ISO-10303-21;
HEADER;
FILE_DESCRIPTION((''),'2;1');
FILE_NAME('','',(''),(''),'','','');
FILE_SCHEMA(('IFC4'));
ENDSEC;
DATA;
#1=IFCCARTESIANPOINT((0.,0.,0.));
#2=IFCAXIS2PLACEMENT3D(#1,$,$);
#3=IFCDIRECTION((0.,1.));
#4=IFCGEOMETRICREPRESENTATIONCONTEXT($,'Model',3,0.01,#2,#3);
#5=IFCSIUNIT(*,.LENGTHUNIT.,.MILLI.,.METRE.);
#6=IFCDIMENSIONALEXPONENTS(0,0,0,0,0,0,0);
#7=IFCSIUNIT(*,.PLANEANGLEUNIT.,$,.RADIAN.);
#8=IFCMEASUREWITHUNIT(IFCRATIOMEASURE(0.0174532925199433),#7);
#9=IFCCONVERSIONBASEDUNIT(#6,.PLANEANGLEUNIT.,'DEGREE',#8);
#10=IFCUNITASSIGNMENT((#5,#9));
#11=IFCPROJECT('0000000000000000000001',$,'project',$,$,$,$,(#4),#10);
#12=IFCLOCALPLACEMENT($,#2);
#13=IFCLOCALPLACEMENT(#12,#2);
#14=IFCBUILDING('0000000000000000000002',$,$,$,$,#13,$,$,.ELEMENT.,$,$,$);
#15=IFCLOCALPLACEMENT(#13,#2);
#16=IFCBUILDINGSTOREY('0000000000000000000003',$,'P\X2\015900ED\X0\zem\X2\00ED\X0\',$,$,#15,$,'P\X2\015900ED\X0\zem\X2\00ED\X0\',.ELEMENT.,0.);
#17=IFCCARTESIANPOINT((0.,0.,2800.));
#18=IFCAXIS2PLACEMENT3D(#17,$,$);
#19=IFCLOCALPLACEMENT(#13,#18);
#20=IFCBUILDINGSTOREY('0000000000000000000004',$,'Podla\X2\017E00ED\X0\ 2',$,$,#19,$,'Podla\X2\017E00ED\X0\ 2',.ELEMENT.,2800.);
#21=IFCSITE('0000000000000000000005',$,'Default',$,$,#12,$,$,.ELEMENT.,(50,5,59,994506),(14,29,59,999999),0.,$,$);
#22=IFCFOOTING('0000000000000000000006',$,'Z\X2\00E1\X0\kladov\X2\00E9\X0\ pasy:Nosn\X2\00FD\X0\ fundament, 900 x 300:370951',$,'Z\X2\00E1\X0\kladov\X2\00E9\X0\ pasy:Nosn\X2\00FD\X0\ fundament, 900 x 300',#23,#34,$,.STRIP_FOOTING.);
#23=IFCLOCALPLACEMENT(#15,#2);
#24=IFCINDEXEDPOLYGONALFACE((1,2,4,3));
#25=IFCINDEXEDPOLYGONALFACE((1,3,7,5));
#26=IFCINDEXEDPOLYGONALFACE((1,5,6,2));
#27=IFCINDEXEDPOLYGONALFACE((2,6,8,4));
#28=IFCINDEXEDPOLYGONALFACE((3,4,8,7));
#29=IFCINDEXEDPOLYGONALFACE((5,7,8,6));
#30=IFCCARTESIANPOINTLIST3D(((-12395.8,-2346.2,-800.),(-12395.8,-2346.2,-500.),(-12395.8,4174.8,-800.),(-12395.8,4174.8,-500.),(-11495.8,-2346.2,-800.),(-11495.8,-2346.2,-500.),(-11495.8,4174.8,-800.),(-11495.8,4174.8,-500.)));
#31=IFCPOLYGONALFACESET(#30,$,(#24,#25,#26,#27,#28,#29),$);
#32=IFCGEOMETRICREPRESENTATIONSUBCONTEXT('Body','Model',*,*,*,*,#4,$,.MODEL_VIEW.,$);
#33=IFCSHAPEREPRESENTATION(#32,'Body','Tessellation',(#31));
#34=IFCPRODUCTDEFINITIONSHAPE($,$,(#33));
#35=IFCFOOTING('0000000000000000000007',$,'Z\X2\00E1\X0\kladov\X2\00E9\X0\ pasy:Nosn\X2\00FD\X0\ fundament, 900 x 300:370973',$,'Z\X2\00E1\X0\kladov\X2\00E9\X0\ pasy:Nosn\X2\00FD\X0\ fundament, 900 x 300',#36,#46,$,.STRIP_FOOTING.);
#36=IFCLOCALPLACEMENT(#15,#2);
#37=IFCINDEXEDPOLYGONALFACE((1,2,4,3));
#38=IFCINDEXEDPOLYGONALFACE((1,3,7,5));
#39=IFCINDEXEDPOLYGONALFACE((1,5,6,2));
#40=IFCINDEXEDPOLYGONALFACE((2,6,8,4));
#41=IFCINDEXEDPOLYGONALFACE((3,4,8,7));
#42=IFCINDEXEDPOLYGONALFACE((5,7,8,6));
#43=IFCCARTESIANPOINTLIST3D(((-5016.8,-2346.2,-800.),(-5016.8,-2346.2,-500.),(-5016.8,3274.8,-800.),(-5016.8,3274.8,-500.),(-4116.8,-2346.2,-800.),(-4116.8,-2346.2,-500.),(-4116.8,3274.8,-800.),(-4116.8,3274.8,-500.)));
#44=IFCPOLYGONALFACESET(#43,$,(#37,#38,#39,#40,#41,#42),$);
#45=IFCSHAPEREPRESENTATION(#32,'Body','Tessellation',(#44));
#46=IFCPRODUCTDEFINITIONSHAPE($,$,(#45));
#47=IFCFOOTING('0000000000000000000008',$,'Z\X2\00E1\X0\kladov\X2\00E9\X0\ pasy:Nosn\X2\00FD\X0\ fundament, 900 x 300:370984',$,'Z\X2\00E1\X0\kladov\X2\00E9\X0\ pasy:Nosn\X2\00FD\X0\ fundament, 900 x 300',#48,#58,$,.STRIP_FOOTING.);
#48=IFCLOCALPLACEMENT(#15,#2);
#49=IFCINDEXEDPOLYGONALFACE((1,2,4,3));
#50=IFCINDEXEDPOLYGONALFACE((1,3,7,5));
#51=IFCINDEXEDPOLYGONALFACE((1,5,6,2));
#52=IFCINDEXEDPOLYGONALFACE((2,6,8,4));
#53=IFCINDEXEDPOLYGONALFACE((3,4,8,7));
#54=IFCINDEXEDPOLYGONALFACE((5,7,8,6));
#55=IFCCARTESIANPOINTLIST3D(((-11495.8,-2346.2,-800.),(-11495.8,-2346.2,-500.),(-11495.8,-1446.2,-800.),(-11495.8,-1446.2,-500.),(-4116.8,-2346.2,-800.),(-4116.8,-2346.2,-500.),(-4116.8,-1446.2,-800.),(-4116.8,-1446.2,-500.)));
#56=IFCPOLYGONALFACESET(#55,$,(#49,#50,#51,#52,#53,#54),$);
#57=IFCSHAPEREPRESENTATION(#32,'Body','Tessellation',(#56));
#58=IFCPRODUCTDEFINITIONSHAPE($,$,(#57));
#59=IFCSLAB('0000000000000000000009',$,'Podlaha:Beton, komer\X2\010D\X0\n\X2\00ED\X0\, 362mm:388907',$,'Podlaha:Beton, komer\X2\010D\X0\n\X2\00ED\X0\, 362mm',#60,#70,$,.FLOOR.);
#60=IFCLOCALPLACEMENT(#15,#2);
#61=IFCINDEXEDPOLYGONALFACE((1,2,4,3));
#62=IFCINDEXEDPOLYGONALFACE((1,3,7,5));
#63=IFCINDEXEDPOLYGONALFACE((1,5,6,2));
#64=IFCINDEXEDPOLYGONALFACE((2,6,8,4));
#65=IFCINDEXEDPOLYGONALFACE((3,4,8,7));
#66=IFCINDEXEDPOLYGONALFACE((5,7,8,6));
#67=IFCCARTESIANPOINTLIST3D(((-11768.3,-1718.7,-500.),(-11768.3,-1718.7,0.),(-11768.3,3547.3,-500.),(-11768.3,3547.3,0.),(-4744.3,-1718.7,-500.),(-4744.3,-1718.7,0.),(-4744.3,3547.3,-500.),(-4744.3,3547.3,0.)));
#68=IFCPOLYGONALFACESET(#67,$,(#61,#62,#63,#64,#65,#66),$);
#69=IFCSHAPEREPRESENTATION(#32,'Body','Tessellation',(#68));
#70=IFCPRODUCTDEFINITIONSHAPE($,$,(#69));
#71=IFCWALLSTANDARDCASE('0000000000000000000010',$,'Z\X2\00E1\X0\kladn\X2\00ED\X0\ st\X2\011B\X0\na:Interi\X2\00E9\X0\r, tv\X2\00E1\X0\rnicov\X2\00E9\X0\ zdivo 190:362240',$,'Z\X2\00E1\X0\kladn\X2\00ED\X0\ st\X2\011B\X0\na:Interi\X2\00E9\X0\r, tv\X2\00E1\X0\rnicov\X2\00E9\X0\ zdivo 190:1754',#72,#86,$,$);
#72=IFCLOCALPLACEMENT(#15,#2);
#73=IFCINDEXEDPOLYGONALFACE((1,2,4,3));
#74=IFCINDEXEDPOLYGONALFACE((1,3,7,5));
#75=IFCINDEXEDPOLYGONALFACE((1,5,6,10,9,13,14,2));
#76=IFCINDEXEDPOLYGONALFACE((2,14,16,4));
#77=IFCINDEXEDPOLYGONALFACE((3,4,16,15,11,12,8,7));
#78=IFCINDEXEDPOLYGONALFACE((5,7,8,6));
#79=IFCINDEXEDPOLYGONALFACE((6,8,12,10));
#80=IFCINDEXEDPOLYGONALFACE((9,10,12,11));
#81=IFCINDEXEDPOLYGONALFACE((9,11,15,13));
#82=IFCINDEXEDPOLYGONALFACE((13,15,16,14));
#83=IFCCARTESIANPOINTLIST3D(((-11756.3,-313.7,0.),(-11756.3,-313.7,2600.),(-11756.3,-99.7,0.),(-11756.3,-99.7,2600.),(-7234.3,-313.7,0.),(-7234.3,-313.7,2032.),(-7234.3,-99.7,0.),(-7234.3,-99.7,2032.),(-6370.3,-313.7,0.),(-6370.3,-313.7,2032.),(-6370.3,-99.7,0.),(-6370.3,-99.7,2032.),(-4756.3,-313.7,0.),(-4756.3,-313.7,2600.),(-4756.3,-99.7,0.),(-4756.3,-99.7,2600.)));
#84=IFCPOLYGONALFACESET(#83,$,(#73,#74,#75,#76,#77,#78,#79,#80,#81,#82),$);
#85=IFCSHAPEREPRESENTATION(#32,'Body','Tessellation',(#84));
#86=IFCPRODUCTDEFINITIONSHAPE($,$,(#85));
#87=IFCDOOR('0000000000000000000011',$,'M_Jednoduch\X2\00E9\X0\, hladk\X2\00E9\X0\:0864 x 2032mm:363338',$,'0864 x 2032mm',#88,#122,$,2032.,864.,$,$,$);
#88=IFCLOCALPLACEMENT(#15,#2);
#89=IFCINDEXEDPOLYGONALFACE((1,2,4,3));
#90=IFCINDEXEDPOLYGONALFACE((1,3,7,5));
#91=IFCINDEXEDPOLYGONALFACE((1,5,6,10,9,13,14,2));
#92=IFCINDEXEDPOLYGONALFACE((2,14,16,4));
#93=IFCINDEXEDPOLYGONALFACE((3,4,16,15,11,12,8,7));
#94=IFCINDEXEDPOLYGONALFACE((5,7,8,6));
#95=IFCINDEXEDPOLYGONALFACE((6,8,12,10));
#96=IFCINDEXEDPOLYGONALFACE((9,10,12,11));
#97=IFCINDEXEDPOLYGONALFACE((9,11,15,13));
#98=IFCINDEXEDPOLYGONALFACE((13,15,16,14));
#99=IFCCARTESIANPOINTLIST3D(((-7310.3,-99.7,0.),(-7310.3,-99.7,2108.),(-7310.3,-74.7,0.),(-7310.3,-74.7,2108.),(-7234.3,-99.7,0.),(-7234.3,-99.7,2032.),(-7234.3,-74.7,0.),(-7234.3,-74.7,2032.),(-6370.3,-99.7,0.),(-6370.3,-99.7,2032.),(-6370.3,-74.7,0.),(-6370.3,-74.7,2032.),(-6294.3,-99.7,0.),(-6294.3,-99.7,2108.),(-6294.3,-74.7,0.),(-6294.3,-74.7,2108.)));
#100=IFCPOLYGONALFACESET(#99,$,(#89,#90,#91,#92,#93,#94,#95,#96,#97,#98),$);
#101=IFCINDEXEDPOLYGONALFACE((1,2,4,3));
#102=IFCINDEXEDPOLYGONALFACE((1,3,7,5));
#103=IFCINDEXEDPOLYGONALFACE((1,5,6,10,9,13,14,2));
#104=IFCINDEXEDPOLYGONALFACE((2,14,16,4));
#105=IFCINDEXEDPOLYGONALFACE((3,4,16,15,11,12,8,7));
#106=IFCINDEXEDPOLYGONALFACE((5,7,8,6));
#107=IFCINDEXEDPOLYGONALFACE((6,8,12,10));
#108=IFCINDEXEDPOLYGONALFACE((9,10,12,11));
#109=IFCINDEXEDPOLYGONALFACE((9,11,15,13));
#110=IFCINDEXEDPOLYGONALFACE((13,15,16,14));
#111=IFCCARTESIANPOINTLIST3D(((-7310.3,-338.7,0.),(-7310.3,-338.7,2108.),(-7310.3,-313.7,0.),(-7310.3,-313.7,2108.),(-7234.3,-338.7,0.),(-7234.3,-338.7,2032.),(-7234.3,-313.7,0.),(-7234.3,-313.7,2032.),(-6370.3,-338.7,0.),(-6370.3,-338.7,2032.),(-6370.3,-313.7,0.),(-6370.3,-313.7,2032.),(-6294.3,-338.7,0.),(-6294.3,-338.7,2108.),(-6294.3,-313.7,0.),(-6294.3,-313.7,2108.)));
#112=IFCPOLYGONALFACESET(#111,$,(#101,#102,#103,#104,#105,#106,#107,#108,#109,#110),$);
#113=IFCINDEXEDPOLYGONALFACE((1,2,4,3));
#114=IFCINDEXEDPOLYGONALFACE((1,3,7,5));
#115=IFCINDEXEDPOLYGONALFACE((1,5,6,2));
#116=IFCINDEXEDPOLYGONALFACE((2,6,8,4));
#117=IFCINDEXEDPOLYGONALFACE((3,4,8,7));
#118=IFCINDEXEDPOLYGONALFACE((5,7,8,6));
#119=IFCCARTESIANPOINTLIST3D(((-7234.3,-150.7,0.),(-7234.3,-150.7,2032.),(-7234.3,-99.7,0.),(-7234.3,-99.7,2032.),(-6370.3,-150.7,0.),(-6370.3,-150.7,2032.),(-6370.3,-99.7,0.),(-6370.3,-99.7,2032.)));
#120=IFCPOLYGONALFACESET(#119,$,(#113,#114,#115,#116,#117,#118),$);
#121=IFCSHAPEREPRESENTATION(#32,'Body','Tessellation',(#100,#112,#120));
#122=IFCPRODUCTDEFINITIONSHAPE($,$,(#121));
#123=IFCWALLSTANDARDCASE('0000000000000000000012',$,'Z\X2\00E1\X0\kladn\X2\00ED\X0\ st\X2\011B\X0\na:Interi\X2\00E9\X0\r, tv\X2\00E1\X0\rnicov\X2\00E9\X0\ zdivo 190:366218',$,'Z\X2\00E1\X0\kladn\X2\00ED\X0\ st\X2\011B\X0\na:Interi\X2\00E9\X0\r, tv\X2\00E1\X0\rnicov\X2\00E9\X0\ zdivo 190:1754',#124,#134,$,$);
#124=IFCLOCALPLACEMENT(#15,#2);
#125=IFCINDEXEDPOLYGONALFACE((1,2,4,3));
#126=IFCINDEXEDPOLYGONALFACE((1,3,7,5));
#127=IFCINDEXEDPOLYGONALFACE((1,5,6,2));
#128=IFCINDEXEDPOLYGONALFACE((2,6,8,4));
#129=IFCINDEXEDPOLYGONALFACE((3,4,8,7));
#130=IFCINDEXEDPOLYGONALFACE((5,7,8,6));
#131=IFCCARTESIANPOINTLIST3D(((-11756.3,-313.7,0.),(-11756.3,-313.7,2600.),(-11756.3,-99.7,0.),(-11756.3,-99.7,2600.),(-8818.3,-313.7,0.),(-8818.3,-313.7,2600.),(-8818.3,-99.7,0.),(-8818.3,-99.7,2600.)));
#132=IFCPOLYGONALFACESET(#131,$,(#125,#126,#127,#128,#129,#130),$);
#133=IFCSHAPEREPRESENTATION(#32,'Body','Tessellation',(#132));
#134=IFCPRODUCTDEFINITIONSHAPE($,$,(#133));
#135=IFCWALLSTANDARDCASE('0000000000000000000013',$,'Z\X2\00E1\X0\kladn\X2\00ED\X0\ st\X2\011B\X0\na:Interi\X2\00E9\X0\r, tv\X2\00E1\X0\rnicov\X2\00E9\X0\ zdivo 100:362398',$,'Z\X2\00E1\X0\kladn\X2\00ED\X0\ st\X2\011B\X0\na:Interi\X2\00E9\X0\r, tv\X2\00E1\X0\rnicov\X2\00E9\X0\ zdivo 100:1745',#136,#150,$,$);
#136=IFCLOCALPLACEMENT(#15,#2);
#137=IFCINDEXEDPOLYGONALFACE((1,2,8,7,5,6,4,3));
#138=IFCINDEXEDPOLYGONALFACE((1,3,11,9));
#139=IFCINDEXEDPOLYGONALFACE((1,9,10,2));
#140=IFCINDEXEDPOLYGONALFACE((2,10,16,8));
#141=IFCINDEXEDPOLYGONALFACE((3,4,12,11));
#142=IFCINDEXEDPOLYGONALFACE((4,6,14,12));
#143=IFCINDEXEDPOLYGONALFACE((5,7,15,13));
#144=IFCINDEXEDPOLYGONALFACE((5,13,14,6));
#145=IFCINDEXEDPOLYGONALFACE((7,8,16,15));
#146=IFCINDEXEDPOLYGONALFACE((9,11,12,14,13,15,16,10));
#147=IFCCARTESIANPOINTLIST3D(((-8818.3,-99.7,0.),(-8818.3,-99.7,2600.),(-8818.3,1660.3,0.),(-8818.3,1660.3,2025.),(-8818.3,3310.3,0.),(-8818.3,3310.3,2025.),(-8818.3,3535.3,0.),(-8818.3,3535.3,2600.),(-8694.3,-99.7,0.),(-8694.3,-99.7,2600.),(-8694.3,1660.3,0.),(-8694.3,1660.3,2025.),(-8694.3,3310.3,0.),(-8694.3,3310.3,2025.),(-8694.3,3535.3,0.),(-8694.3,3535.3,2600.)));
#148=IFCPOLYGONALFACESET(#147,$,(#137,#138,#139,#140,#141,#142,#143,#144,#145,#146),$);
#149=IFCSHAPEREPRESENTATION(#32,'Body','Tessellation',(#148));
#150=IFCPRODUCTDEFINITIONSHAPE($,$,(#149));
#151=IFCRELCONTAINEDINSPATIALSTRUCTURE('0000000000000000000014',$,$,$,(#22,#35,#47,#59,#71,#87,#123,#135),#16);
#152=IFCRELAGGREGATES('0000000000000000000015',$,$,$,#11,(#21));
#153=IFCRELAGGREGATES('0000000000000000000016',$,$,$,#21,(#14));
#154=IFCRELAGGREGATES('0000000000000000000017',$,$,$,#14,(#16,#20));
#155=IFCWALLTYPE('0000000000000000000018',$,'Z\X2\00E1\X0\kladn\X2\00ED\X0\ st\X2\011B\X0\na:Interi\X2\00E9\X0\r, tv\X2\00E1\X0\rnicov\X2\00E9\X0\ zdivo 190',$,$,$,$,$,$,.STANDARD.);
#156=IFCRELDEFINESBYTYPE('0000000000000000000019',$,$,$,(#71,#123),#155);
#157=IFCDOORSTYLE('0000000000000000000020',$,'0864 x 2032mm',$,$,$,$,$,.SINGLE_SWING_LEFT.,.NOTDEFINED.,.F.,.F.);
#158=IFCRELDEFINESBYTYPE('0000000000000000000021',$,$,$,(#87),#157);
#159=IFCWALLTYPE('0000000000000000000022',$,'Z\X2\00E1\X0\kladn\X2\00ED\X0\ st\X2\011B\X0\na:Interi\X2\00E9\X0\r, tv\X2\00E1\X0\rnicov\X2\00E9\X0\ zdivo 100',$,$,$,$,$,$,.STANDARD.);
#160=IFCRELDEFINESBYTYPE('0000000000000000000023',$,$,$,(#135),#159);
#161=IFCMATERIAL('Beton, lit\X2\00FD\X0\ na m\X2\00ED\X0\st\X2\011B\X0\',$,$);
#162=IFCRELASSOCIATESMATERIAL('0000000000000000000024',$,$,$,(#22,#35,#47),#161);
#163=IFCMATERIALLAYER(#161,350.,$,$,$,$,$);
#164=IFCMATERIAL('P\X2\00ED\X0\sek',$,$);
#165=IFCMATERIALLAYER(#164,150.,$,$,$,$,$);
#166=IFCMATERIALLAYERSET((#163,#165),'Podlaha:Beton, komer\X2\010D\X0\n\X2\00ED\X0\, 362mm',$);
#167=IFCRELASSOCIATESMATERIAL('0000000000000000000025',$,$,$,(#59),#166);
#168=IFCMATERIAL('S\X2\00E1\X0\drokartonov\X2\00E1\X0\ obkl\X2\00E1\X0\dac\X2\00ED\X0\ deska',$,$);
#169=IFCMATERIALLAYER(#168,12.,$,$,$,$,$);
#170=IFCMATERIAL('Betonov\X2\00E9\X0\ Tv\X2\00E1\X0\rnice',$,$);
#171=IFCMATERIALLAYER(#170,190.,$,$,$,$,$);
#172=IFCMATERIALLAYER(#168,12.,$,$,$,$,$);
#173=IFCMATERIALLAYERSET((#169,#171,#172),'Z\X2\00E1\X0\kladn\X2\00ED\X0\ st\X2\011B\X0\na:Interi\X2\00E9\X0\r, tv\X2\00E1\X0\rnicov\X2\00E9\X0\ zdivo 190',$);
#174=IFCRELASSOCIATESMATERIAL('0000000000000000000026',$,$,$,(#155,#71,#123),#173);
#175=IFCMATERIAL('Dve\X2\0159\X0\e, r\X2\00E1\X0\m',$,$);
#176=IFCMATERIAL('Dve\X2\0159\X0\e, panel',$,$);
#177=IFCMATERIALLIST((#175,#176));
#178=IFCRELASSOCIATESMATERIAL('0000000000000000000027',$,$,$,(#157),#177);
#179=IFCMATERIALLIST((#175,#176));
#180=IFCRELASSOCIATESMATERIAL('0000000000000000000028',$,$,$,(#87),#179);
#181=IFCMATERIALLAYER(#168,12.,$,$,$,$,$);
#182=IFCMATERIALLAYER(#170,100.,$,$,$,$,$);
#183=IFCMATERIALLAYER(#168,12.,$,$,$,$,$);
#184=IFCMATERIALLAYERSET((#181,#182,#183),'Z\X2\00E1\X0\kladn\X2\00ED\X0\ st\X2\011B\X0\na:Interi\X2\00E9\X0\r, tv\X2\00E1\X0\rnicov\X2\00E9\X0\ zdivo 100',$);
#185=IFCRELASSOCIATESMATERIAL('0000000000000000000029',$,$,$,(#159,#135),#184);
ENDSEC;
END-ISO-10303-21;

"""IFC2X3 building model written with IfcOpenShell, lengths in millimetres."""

from ifc_helpers import new_model, entity, si_unit, converted_unit, direction, frame, frame_2d, origin, origin_2d_with_axis, place, context, subcontext, project, spatial, polyline, rectangle, outline, extrude, clip, bounded_halfspace, source, transform, mapped, material, material_list, layer, layer_set, layer_usage, type_object, type_shapes, element, fill, save


model = new_model("IFC2X3")

# Units and contexts
model_context = context("Model", 3, precision=0.01, world=origin(), true_north=direction((0.0, 1.0)))
body_context = subcontext(model_context, "Body", "Model", "MODEL_VIEW")
ifc_project = project(units=[si_unit("LENGTHUNIT", "METRE", prefix="MILLI"), converted_unit("PLANEANGLEUNIT", "DEGREE", entity("IfcRatioMeasure", 0.0174532925199433), si_unit("PLANEANGLEUNIT", "RADIAN"), dimensions=[0, 0, 0, 0, 0, 0, 0])], contexts=[model_context])

# Site, building, storey
site_placement = place(None, origin())
site = spatial("IfcSite", under=ifc_project, at=site_placement, Name="Default", CompositionType="ELEMENT", RefLatitude=(50, 5, 59, 994506), RefLongitude=(14, 29, 59, 999999), RefElevation=0.0)
building_placement = place(site_placement, origin())
building = spatial("IfcBuilding", under=site, at=building_placement, CompositionType="ELEMENT")
storey_1_placement = place(building_placement, origin())
storey_1 = spatial("IfcBuildingStorey", under=building, at=storey_1_placement, Name="Přízemí", LongName="Přízemí", CompositionType="ELEMENT", Elevation=0.0)

# Footings
ifc_material_1 = material(Name="Beton, litý na místě")
footing_1_placement = place(storey_1_placement, origin())
element("IfcFooting", 1, at=footing_1_placement, inside=storey_1, material=ifc_material_1, Name="Základové pasy:Nosný fundament, 900 x 300:370951", ObjectType="Základové pasy:Nosný fundament, 900 x 300", PredefinedType="STRIP_FOOTING", context=body_context, shape_type="SweptSolid", body=[
    extrude(rectangle(XDim=6521.0, YDim=900.0, at=frame_2d((0.0, -150.0), x_axis=(1.0, 0.0))), frame((-11795.8, 914.3, -800.0), z_axis=(0.0, 0.0, 1.0), x_axis=(0.0, -1.0, 0.0)), (0.0, 0.0, 1.0), 300.0),
])
footing_2_placement = place(storey_1_placement, origin())
element("IfcFooting", 2, at=footing_2_placement, inside=storey_1, material=ifc_material_1, Name="Základové pasy:Nosný fundament, 900 x 300:370973", ObjectType="Základové pasy:Nosný fundament, 900 x 300", PredefinedType="STRIP_FOOTING", context=body_context, shape_type="SweptSolid", body=[
    extrude(rectangle(XDim=5621.0, YDim=900.0, at=frame_2d((0.0, 0.0), x_axis=(1.0, 0.0))), frame((-4566.8, 464.3, -800.0), z_axis=(0.0, 0.0, 1.0), x_axis=(0.0, 1.0, 0.0)), (0.0, 0.0, 1.0), 300.0),
])
footing_3_placement = place(storey_1_placement, origin())
element("IfcFooting", 3, at=footing_3_placement, inside=storey_1, material=ifc_material_1, Name="Základové pasy:Nosný fundament, 900 x 300:370984", ObjectType="Základové pasy:Nosný fundament, 900 x 300", PredefinedType="STRIP_FOOTING", context=body_context, shape_type="SweptSolid", body=[
    extrude(rectangle(XDim=7379.0, YDim=900.0, at=origin_2d_with_axis()), frame((-7806.3, -1896.2, -800.0), z_axis=(0.0, 0.0, 1.0), x_axis=(-1.0, 0.0, 0.0)), (0.0, 0.0, 1.0), 300.0),
])

# Slab
ifc_layer_1 = layer(ifc_material_1, 350.0)
ifc_material_2 = material(Name="Písek")
ifc_layer_2 = layer(ifc_material_2, 150.0)
ifc_layer_set_1 = layer_set([ifc_layer_1, ifc_layer_2], Name="Podlaha:Beton, komerční, 362mm")
ifc_layer_usage_1 = layer_usage(ifc_layer_set_1, "AXIS3", "POSITIVE", 0.0)
slab_placement = place(storey_1_placement, origin())
element("IfcSlab", 4, at=slab_placement, inside=storey_1, material=ifc_layer_usage_1, Name="Podlaha:Beton, komerční, 362mm:388907", ObjectType="Podlaha:Beton, komerční, 362mm", PredefinedType="FLOOR", context=body_context, shape_type="SweptSolid", body=[
    extrude(rectangle(XDim=5266.0, YDim=7024.0, at=frame_2d((0.0, 0.0), x_axis=(1.0, 0.0))), frame((-8256.3, 914.3, 0.0), z_axis=(0.0, 0.0, -1.0), x_axis=(0.0, 1.0, 0.0)), (0.0, 0.0, 1.0), 500.0),
])

# Shared definitions
ifc_material_3 = material(Name="Betonové Tvárnice")
ifc_material_4 = material(Name="Sádrokartonová obkládací deska")

# Shared definitions
storey_2_placement = place(building_placement, frame((0.0, 0.0, 2800.0)))
storey_2 = spatial("IfcBuildingStorey", under=building, at=storey_2_placement, Name="Podlaží 2", LongName="Podlaží 2", CompositionType="ELEMENT", Elevation=2800.0)

# Wall, opening, door
ifc_layer_3 = layer(ifc_material_4, 12.0)
ifc_layer_4 = layer(ifc_material_3, 190.0)
ifc_layer_5 = layer(ifc_material_4, 12.0)
ifc_layer_set_2 = layer_set([ifc_layer_3, ifc_layer_4, ifc_layer_5], Name="Základní stěna:Interiér, tvárnicové zdivo 190")
ifc_layer_usage_2 = layer_usage(ifc_layer_set_2, "AXIS2", "NEGATIVE", 107.0)
wall_type_1 = type_object("IfcWallType", Name="Základní stěna:Interiér, tvárnicové zdivo 190", PredefinedType="STANDARD", material=ifc_layer_set_2)
wall_1_placement = place(storey_1_placement, frame((-4756.3, -206.7, 0.0), z_axis=(0.0, 0.0, 1.0), x_axis=(-1.0, 0.0, 0.0)))
wall_1 = element("IfcWallStandardCase", 5, at=wall_1_placement, inside=storey_1, type_object=wall_type_1, material=ifc_layer_usage_2, Name="Základní stěna:Interiér, tvárnicové zdivo 190:362240", ObjectType="Základní stěna:Interiér, tvárnicové zdivo 190:1754", context=body_context, shape_type="Clipping", body=[
    clip(extrude(rectangle(XDim=7000.0, YDim=214.0, at=frame_2d((3500.0, 0.0), x_axis=(-1.0, 0.0))), origin(), (0.0, 0.0, 1.0), 2600.0), bounded_halfspace(frame((0.0, -107.0, 2600.0), z_axis=(0.0, 0.0, -1.0), x_axis=(-1.0, 0.0, 0.0)), True, frame((0.0, -107.0, 2600.0)), polyline([(0.0, 0.0), (1414.0, 0.0), (1538.0, 0.0), (3938.0, 0.0), (4062.0, 0.0), (7000.0, 0.0), (7000.0, 214.0), (0.0, 214.0), (0.0, 0.0)]))),
])
opening_1_placement = place(wall_1_placement, frame((2478.0, 107.0, 0.0)))
opening_1 = element("IfcOpeningElement", 6, at=opening_1_placement, cuts=wall_1, ObjectType="Opening", context=body_context, shape_type="SweptSolid", body=[
    extrude(rectangle(XDim=864.0, YDim=2032.0, at=frame_2d((1016.0, 432.0), x_axis=(0.0, -1.0))), frame((0.0, 0.0, 0.0), z_axis=(0.0, -1.0, 0.0), x_axis=(0.0, 0.0, 1.0)), (0.0, 0.0, 1.0), 214.0),
])
ifc_material_5 = material(Name="Dveře, rám")
ifc_material_6 = material(Name="Dveře, panel")
ifc_material_list_1 = material_list([ifc_material_5, ifc_material_6])
ifc_material_list_2 = material_list([ifc_material_5, ifc_material_6])
door_style_1 = type_object("IfcDoorStyle", Name="0864 x 2032mm", ConstructionType="NOTDEFINED", OperationType="SINGLE_SWING_LEFT", ParameterTakesPrecedence=False, Sizeable=False, material=ifc_material_list_2)
shared_shape_1 = source(origin(), body_context, "Body", "SweptSolid", [
    extrude(outline(polyline([(-508.0, -1073.0), (508.0, -1073.0), (508.0, 1035.0), (432.0, 1035.0), (432.0, -997.0), (-432.0, -997.0), (-432.0, 1035.0), (-508.0, 1035.0), (-508.0, -1073.0)])), frame((432.0, 239.0, 1035.0), z_axis=(0.0, -1.0, 0.0), x_axis=(-1.0, 0.0, 0.0)), (0.0, 0.0, 1.0), 25.0),
    extrude(outline(polyline([(-1073.0, -508.0), (1035.0, -508.0), (1035.0, -432.0), (-997.0, -432.0), (-997.0, 432.0), (1035.0, 432.0), (1035.0, 508.0), (-1073.0, 508.0), (-1073.0, -508.0)])), frame((432.0, 0.0, 1035.0), z_axis=(0.0, -1.0, 0.0), x_axis=(0.0, 0.0, -1.0)), (0.0, 0.0, 1.0), 25.0),
    extrude(rectangle(XDim=864.0, YDim=51.0, at=frame_2d((0.0, 0.0), x_axis=(1.0, 0.0))), frame((432.0, 188.5, 0.0)), (0.0, 0.0, 1.0), 2032.0),
])
type_shapes(door_style_1, [shared_shape_1])
door_1_placement = place(opening_1_placement, frame((0.0, 0.0, 0.0), z_axis=(0.0, 0.0, 1.0), x_axis=(-1.0, 0.0, 0.0)))
door_1 = element("IfcDoor", 7, at=door_1_placement, inside=storey_1, type_object=door_style_1, material=ifc_material_list_1, Name="M_Jednoduché, hladké:0864 x 2032mm:363338", ObjectType="0864 x 2032mm", OverallHeight=2032.0, OverallWidth=864.0, context=body_context, shape_type="MappedRepresentation", body=[
    mapped(shared_shape_1, transform((0.0, 0.0, 0.0), scale=1.0)),
])
fill(opening_1, door_1)

# Wall
ifc_layer_usage_3 = layer_usage(ifc_layer_set_2, "AXIS2", "NEGATIVE", 107.0)
wall_2_placement = place(storey_1_placement, frame((-11756.3, -206.7, 0.0)))
element("IfcWallStandardCase", 8, at=wall_2_placement, inside=storey_1, type_object=wall_type_1, material=ifc_layer_usage_3, Name="Základní stěna:Interiér, tvárnicové zdivo 190:366218", ObjectType="Základní stěna:Interiér, tvárnicové zdivo 190:1754", context=body_context, shape_type="SweptSolid", body=[
    extrude(rectangle(XDim=2938.0, YDim=214.0, at=frame_2d((1469.0, 0.0), x_axis=(-1.0, 0.0))), origin(), (0.0, 0.0, 1.0), 2600.0),
])

# Wall, opening
ifc_layer_6 = layer(ifc_material_4, 12.0)
ifc_layer_7 = layer(ifc_material_3, 100.0)
ifc_layer_8 = layer(ifc_material_4, 12.0)
ifc_layer_set_3 = layer_set([ifc_layer_6, ifc_layer_7, ifc_layer_8], Name="Základní stěna:Interiér, tvárnicové zdivo 100")
ifc_layer_usage_4 = layer_usage(ifc_layer_set_3, "AXIS2", "NEGATIVE", 62.0)
wall_type_2 = type_object("IfcWallType", Name="Základní stěna:Interiér, tvárnicové zdivo 100", PredefinedType="STANDARD", material=ifc_layer_set_3)
wall_3_placement = place(storey_1_placement, frame((-8756.3, -99.7, 0.0), z_axis=(0.0, 0.0, 1.0), x_axis=(0.0, 1.0, 0.0)))
wall_3 = element("IfcWallStandardCase", 9, at=wall_3_placement, inside=storey_1, type_object=wall_type_2, material=ifc_layer_usage_4, Name="Základní stěna:Interiér, tvárnicové zdivo 100:362398", ObjectType="Základní stěna:Interiér, tvárnicové zdivo 100:1745", context=body_context, shape_type="Clipping", body=[
    clip(extrude(rectangle(XDim=3635.0, YDim=124.0, at=frame_2d((1817.5, 0.0), x_axis=(-1.0, 0.0))), origin(), (0.0, 0.0, 1.0), 2600.0), bounded_halfspace(frame((0.0, -62.0, 2600.0), z_axis=(0.0, 0.0, -1.0), x_axis=(0.0, -1.0, 0.0)), True, frame((0.0, -62.0, 2600.0)), polyline([(0.0, 0.0), (1200.0, 0.0), (1324.0, 0.0), (3635.0, 0.0), (3635.0, 124.0), (0.0, 124.0), (0.0, 0.0)]))),
])
opening_2_placement = place(wall_3_placement, frame((1760.0, -62.0, 0.0)))
element("IfcOpeningElement", 10, at=opening_2_placement, cuts=wall_3, ObjectType="Opening", context=body_context, shape_type="SweptSolid", body=[
    extrude(rectangle(XDim=2025.0, YDim=1650.0, at=frame_2d((1012.5, 825.0), x_axis=(1.0, 0.0))), frame((0.0, 0.0, 0.0), z_axis=(0.0, 1.0, 0.0), x_axis=(0.0, 0.0, 1.0)), (0.0, 0.0, 1.0), 124.0),
])

save(model, "model.ifc")
